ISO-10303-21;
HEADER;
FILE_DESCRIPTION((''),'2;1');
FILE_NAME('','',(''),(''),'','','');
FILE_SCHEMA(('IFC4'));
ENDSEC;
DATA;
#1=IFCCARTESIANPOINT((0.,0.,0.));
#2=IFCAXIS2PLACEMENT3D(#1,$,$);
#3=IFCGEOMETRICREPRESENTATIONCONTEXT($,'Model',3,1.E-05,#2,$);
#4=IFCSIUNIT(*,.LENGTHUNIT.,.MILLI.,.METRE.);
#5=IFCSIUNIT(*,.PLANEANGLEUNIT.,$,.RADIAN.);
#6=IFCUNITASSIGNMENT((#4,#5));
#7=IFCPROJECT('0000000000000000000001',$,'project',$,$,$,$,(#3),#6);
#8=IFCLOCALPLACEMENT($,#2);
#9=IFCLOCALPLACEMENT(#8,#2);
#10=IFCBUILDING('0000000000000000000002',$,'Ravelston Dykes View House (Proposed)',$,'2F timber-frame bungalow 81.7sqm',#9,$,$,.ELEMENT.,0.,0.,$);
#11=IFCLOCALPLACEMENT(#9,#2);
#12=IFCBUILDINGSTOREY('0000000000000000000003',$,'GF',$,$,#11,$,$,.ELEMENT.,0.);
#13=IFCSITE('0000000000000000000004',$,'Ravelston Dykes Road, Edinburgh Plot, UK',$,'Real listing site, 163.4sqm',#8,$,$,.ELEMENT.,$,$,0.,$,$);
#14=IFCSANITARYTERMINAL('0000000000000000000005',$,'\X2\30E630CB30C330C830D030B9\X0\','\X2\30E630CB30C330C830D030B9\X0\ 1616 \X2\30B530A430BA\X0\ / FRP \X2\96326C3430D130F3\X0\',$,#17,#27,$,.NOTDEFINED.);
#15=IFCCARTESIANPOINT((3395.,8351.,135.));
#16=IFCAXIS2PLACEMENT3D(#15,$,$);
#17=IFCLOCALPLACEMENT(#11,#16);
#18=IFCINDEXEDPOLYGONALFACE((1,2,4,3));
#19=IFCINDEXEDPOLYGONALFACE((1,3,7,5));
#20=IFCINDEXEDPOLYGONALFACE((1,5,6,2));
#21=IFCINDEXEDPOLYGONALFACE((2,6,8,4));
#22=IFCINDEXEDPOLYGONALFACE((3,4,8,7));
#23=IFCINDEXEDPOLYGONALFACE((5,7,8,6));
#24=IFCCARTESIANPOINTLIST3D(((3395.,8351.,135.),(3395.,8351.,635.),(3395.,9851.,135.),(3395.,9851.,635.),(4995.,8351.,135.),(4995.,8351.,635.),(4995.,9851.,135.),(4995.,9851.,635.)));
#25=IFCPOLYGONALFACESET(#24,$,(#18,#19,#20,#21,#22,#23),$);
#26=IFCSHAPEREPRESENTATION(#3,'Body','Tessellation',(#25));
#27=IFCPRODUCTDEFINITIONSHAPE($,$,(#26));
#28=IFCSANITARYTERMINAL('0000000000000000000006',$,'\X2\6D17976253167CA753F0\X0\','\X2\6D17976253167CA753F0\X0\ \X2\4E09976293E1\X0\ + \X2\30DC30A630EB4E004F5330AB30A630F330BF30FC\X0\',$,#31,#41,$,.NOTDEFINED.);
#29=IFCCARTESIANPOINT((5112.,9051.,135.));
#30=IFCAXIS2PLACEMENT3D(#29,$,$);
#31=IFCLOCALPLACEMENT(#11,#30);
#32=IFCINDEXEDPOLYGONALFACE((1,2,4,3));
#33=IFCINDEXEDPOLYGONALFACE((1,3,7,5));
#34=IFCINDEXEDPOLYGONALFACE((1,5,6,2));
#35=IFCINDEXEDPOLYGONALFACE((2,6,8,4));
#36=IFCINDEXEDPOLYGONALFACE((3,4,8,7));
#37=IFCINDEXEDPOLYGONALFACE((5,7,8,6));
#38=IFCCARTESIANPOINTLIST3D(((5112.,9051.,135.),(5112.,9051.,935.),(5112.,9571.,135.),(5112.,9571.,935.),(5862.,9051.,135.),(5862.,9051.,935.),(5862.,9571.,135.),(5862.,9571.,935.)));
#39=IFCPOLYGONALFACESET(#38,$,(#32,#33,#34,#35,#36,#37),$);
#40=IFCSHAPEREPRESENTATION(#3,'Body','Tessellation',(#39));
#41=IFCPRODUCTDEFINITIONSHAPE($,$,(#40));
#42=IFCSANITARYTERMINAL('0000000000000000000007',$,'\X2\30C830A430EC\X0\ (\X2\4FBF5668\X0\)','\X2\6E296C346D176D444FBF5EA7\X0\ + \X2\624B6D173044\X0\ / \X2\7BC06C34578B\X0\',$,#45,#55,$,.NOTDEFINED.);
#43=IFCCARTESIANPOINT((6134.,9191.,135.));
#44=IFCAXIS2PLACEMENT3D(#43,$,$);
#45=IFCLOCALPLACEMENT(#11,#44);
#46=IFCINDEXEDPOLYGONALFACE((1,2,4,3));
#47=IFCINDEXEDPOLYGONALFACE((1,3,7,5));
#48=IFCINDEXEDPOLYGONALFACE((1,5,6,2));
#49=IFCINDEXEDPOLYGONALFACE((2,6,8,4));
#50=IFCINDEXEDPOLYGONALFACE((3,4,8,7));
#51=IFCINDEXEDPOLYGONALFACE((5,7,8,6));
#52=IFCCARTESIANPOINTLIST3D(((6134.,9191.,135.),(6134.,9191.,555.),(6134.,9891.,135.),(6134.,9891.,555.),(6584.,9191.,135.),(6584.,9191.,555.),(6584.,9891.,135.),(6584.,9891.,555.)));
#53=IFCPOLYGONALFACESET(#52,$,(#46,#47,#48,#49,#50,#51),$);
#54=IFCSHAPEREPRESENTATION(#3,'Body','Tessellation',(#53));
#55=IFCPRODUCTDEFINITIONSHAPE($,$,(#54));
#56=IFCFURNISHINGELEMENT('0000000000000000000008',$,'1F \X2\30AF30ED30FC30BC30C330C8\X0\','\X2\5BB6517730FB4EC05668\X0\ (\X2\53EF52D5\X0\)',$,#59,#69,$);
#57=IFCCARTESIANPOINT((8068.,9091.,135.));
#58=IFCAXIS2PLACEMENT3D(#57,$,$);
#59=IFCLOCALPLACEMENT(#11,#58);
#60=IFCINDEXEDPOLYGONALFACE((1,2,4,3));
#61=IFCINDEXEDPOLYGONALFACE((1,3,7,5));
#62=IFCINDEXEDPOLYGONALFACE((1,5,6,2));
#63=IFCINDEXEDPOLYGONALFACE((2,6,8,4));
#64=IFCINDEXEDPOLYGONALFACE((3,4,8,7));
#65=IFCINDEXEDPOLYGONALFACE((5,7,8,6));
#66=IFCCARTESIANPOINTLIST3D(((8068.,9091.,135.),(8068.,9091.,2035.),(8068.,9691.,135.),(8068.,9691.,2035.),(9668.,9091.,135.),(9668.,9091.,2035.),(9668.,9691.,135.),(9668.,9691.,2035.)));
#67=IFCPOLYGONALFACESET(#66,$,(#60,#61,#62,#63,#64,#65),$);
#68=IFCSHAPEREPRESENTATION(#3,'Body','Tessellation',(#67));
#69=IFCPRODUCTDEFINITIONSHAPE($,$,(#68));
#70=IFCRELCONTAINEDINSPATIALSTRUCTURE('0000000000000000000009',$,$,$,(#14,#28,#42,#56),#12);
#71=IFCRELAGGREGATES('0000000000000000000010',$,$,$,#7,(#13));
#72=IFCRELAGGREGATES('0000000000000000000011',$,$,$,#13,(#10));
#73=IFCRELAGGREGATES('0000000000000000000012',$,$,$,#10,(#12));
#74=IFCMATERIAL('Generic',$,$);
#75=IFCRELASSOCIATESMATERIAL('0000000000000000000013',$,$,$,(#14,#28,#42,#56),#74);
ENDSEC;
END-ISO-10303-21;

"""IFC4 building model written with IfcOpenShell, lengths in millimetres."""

from ifc_helpers import new_model, si_unit, frame, frame_2d, origin, place, context, project, spatial, rectangle, extrude, material, element, save


model = new_model("IFC4")

# Units and contexts
model_context = context("Model", 3, precision=1e-05, world=origin())
ifc_project = project(units=[si_unit("LENGTHUNIT", "METRE", prefix="MILLI"), si_unit("PLANEANGLEUNIT", "RADIAN")], contexts=[model_context])

# Site, building, storey
site_placement = place(None, origin())
site = spatial("IfcSite", under=ifc_project, at=site_placement, Name="Ravelston Dykes Road, Edinburgh Plot, UK", ObjectType="Real listing site, 163.4sqm", CompositionType="ELEMENT", RefElevation=0.0)
building_placement = place(site_placement, origin())
building = spatial("IfcBuilding", under=site, at=building_placement, Name="Ravelston Dykes View House (Proposed)", ObjectType="2F timber-frame bungalow 81.7sqm", CompositionType="ELEMENT", ElevationOfRefHeight=0.0, ElevationOfTerrain=0.0)
storey_placement = place(building_placement, origin())
storey = spatial("IfcBuildingStorey", under=building, at=storey_placement, Name="GF", CompositionType="ELEMENT", Elevation=0.0)

# Shared definitions
ifc_material_1 = material(Name="Generic")

# Sanitary terminals
sanitary_terminal_1_placement = place(storey_placement, frame((3395.0, 8351.0, 135.0)))
element("IfcSanitaryTerminal", 1, at=sanitary_terminal_1_placement, inside=storey, material=ifc_material_1, Name="ユニットバス", Description="ユニットバス 1616 サイズ / FRP 防水パン", PredefinedType="NOTDEFINED", context=model_context, shape_type="SweptSolid", body=[
    extrude(rectangle(XDim=1600.0, YDim=1500.0, at=frame_2d((800.0, 750.0))), frame((3395.0, 8351.0, 135.0)), (0.0, 0.0, 1.0), 500.0),
])
sanitary_terminal_2_placement = place(storey_placement, frame((5112.0, 9051.0, 135.0)))
element("IfcSanitaryTerminal", 2, at=sanitary_terminal_2_placement, inside=storey, material=ifc_material_1, Name="洗面化粧台", Description="洗面化粧台 三面鏡 + ボウル一体カウンター", PredefinedType="NOTDEFINED", context=model_context, shape_type="SweptSolid", body=[
    extrude(rectangle(XDim=750.0, YDim=520.0, at=frame_2d((375.0, 260.0))), frame((5112.0, 9051.0, 135.0)), (0.0, 0.0, 1.0), 800.0),
])
sanitary_terminal_3_placement = place(storey_placement, frame((6134.0, 9191.0, 135.0)))
element("IfcSanitaryTerminal", 3, at=sanitary_terminal_3_placement, inside=storey, material=ifc_material_1, Name="トイレ (便器)", Description="温水洗浄便座 + 手洗い / 節水型", PredefinedType="NOTDEFINED", context=model_context, shape_type="SweptSolid", body=[
    extrude(rectangle(XDim=450.0, YDim=700.0, at=frame_2d((225.0, 350.0))), frame((6134.0, 9191.0, 135.0)), (0.0, 0.0, 1.0), 420.0),
])

# Furnishing element
furnishing_placement = place(storey_placement, frame((8068.0, 9091.0, 135.0)))
element("IfcFurnishingElement", 4, at=furnishing_placement, inside=storey, material=ifc_material_1, Name="1F クローゼット", Description="家具・什器 (可動)", context=model_context, shape_type="SweptSolid", body=[
    extrude(rectangle(XDim=1600.0, YDim=600.0, at=frame_2d((800.0, 300.0))), frame((8068.0, 9091.0, 135.0)), (0.0, 0.0, 1.0), 1900.0),
])

save(model, "model.ifc")
